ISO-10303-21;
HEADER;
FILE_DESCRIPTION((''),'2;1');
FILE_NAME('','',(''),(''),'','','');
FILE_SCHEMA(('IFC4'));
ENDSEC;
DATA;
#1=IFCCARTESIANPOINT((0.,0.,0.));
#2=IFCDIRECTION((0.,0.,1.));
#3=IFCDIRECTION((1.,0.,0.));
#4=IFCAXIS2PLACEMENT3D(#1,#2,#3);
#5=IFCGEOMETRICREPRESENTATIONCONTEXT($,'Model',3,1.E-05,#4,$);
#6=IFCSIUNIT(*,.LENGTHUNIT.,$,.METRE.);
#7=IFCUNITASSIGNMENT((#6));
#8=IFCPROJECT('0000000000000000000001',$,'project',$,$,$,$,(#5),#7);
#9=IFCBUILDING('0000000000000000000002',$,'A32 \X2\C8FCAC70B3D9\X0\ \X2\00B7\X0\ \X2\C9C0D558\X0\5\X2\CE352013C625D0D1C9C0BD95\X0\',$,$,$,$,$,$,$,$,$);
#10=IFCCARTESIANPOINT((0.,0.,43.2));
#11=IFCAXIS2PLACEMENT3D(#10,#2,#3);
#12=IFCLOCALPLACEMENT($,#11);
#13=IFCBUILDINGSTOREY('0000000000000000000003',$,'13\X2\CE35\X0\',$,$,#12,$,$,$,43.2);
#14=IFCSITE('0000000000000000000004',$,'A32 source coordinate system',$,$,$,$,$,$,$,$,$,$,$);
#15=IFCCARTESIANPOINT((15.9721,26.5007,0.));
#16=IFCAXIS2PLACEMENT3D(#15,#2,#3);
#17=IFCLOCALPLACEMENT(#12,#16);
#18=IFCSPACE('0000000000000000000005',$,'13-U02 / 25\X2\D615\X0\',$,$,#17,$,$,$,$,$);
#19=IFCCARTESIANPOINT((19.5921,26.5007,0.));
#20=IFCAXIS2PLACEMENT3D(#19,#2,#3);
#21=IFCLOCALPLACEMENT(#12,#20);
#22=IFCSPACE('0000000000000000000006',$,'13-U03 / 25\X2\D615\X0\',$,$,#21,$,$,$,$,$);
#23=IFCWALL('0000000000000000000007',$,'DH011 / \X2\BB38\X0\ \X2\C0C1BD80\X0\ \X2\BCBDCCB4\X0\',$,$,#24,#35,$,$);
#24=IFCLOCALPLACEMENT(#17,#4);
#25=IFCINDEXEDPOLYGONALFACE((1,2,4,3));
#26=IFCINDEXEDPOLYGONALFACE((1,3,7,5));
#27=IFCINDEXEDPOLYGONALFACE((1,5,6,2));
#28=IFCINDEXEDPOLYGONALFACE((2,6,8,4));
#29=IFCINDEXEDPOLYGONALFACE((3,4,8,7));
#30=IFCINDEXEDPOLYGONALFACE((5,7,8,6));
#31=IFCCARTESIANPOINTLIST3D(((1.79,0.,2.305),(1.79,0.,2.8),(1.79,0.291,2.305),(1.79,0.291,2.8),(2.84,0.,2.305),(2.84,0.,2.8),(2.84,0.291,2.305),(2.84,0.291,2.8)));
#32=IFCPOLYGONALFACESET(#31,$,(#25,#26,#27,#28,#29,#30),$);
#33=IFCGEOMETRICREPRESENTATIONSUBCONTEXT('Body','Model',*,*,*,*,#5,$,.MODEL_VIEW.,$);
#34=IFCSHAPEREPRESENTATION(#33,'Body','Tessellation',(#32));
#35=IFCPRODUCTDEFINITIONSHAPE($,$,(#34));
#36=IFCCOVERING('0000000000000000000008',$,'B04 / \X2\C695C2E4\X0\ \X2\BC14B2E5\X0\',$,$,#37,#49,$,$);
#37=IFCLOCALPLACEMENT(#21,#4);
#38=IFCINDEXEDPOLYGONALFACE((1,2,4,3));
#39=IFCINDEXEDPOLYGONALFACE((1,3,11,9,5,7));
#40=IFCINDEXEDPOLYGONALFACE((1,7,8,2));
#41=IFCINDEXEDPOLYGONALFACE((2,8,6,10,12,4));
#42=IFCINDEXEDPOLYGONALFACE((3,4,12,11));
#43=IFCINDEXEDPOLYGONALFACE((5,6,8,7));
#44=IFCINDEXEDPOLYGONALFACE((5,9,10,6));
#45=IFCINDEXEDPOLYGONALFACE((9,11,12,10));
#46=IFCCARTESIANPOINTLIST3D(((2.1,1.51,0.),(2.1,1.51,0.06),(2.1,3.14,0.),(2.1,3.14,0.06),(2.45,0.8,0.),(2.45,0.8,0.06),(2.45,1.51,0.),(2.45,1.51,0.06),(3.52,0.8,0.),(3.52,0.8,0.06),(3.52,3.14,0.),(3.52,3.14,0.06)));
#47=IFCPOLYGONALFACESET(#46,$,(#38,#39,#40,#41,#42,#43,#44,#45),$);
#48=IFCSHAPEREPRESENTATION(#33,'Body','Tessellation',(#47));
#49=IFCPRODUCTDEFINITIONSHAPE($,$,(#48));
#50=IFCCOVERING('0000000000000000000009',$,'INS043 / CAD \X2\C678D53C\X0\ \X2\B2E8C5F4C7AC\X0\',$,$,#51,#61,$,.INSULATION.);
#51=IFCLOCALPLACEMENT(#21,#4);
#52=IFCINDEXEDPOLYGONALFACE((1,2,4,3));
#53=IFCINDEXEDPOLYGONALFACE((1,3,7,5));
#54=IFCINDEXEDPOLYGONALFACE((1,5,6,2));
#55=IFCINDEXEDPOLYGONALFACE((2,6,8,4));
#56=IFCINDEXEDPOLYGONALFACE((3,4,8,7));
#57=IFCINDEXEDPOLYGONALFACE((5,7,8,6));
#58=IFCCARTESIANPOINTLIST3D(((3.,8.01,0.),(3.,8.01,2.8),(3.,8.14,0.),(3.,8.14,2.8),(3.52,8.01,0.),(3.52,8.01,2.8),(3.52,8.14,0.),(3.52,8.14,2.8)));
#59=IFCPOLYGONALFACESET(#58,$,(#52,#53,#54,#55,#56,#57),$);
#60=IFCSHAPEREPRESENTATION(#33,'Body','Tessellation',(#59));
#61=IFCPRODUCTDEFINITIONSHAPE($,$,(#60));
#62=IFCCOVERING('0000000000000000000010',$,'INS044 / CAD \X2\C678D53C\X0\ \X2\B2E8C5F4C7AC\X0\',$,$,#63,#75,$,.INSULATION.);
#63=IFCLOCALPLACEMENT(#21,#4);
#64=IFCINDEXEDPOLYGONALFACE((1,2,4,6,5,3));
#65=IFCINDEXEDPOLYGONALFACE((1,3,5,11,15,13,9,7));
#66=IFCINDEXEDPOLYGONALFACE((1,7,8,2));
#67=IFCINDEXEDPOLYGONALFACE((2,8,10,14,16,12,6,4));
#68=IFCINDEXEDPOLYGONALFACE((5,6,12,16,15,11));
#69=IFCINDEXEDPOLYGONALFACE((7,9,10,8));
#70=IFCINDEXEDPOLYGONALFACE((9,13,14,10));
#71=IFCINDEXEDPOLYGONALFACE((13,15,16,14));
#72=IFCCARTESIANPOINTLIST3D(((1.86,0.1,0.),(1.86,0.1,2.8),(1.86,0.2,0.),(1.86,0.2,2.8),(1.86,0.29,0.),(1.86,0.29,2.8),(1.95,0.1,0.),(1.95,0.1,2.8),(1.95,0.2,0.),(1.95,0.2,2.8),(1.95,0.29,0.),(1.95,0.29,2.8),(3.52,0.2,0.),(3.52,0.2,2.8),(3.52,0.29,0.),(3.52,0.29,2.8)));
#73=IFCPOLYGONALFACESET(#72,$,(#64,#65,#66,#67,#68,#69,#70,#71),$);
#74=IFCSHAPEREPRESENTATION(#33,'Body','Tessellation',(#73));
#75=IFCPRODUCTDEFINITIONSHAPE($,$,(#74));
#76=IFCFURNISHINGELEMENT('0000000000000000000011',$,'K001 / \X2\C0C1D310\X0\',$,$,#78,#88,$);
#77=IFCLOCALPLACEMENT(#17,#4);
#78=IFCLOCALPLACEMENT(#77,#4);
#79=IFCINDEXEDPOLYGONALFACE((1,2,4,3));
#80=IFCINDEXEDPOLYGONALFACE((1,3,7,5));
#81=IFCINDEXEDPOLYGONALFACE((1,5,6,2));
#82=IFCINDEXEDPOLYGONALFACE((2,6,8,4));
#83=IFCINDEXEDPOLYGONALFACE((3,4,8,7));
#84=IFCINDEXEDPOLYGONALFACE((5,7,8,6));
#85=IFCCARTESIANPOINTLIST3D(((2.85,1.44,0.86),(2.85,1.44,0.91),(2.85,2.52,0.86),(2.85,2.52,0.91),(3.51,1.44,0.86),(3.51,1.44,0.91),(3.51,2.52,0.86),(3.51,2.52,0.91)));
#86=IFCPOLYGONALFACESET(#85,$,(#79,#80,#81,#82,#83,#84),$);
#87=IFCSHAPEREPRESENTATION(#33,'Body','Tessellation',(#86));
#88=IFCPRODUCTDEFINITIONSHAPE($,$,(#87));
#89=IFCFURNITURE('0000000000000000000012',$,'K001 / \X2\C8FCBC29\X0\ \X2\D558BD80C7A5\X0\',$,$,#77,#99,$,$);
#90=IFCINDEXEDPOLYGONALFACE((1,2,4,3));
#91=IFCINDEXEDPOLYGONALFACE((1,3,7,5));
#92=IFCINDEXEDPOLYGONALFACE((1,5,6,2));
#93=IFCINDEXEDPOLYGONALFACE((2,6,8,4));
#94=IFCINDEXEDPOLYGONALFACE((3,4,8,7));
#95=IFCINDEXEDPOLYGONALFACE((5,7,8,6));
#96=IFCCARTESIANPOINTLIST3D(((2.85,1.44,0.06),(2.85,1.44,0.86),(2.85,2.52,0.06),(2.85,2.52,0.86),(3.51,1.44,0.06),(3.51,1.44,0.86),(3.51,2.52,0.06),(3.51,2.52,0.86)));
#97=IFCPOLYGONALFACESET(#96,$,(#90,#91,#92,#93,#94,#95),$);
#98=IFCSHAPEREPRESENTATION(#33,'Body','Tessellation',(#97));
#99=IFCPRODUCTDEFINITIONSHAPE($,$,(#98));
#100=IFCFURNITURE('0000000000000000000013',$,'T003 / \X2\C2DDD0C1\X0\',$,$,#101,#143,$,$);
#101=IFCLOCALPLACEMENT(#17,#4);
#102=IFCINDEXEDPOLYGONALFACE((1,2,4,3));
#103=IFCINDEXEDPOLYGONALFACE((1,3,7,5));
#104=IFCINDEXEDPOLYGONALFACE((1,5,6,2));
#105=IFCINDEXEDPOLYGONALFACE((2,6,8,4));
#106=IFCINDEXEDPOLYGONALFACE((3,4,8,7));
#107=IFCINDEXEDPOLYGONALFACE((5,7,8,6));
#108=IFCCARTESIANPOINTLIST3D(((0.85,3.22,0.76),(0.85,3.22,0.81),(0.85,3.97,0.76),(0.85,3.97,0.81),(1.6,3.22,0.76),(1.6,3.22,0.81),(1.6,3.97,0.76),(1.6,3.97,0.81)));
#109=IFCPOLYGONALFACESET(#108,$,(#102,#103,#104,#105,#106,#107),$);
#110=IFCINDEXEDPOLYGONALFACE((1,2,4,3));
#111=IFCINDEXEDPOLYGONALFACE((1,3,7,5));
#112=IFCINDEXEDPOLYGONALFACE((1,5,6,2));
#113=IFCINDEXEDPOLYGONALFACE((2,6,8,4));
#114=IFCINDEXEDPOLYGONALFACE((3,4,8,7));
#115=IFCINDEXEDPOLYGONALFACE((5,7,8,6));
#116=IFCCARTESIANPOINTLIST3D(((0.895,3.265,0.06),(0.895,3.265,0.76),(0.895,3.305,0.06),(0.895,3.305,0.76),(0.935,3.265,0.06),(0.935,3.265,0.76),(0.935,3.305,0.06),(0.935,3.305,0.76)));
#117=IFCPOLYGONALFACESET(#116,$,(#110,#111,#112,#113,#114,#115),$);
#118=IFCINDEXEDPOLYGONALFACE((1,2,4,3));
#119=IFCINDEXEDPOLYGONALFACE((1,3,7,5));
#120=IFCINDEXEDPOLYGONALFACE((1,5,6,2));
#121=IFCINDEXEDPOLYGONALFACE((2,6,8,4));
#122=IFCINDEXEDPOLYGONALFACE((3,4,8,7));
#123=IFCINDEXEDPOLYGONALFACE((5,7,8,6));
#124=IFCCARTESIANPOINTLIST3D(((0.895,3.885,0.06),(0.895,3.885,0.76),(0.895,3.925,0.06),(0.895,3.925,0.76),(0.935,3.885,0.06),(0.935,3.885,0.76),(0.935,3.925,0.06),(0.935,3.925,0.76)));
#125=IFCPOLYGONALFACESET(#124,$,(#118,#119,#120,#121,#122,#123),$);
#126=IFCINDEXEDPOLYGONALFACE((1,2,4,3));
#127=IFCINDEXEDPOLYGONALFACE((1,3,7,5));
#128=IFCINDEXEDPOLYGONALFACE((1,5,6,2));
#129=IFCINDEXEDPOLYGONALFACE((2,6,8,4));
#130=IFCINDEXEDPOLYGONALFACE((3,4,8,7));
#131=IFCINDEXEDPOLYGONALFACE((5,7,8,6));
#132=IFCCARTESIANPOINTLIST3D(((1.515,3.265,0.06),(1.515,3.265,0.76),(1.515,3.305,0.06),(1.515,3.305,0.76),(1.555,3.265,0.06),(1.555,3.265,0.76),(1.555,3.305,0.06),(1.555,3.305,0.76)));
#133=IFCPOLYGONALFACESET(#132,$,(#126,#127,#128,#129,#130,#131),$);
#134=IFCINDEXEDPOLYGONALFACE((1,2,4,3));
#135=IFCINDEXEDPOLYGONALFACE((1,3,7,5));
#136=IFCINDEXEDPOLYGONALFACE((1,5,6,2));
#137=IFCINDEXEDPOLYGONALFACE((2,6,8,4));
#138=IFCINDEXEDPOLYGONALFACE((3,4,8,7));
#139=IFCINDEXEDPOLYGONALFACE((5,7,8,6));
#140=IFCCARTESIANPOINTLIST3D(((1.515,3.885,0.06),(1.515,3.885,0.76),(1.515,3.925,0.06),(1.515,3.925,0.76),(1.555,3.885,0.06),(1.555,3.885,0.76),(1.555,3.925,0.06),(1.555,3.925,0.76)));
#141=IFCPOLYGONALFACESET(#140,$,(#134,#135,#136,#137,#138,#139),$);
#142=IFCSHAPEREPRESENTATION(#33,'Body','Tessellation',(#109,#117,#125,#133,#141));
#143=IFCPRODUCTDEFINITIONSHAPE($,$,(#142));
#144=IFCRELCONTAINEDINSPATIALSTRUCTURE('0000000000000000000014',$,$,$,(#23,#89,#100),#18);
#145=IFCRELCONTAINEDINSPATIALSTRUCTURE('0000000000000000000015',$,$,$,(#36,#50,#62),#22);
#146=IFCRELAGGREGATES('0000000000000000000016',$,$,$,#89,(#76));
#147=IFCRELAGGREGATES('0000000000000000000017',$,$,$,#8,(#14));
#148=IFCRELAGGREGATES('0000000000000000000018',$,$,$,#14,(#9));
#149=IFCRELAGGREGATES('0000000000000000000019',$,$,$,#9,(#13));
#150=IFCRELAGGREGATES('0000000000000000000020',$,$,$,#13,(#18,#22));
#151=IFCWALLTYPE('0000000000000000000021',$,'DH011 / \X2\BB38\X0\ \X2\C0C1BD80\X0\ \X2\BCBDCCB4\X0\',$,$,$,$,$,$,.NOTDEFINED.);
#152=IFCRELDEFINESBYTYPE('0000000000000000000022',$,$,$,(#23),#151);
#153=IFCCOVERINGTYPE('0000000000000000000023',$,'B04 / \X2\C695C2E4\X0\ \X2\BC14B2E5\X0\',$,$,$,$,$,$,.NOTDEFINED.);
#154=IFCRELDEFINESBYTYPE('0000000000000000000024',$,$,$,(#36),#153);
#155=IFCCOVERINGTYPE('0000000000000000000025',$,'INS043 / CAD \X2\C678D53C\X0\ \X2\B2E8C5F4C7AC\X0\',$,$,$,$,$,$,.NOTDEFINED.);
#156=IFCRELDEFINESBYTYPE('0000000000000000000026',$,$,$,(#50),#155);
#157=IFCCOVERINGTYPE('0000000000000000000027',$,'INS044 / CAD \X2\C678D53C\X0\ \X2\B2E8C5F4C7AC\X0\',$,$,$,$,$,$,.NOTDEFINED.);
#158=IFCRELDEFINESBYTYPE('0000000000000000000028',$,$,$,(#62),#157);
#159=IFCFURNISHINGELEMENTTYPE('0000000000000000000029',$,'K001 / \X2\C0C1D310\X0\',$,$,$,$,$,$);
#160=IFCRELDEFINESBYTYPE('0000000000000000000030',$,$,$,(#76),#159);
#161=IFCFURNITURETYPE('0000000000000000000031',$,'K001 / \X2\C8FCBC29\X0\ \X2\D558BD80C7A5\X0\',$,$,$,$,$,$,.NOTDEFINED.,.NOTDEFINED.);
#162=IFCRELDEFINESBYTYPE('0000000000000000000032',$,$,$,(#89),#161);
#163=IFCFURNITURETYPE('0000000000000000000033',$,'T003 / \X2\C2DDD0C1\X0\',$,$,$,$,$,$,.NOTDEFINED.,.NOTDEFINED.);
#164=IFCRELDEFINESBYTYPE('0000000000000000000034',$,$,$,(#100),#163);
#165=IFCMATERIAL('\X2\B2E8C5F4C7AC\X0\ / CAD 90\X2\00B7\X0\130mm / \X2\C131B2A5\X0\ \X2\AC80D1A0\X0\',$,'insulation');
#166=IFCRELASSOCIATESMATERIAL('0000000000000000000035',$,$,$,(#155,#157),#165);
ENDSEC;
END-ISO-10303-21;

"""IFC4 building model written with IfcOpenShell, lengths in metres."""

from ifc_helpers import new_model, si_unit, frame, origin, origin_with_axes, place, context, subcontext, project, spatial, polyline, outline, extrude, source, transform, mapped, material, type_object, type_shapes, element, aggregate, save


model = new_model("IFC4")

# Units and contexts
model_context = context("Model", 3, precision=1e-05, world=origin_with_axes())
body_context = subcontext(model_context, "Body", "Model", "MODEL_VIEW")
ifc_project = project(units=[si_unit("LENGTHUNIT", "METRE")], contexts=[model_context])

# Site, building, storey, space
site = spatial("IfcSite", under=ifc_project, Name="A32 source coordinate system")
building = spatial("IfcBuilding", under=site, Name="A32 주거동 · 지하5층–옥탑지붕")
storey_placement = place(None, frame((0.0, 0.0, 43.2), z_axis=(0.0, 0.0, 1.0), x_axis=(1.0, 0.0, 0.0)))
storey = spatial("IfcBuildingStorey", under=building, at=storey_placement, Name="13층", Elevation=43.2)
space_1_placement = place(storey_placement, frame((15.9721, 26.5007, 0.0), z_axis=(0.0, 0.0, 1.0), x_axis=(1.0, 0.0, 0.0)))
space_1 = spatial("IfcSpace", under=storey, at=space_1_placement, Name="13-U02 / 25형")

# Wall
wall_type_1 = type_object("IfcWallType", Name="DH011 / 문 상부 벽체", PredefinedType="NOTDEFINED")
shared_shape_1 = source(origin(), body_context, "Body", "SweptSolid", [
    extrude(outline(polyline([(2.84, 0.0), (1.79, 0.0), (1.79, 0.291), (2.84, 0.291), (2.84, 0.0)])), frame((0.0, 0.0, 2.305)), (0.0, 0.0, 1.0), 0.495),
])
type_shapes(wall_type_1, [shared_shape_1])
wall_1_placement = place(space_1_placement, origin_with_axes())
element("IfcWall", 1, at=wall_1_placement, inside=space_1, type_object=wall_type_1, Name="DH011 / 문 상부 벽체", context=body_context, shape_type="MappedRepresentation", body=[
    mapped(shared_shape_1, transform((0.0, 0.0, 0.0), scale=1.0)),
])

# Shared definitions
space_2_placement = place(storey_placement, frame((19.5921, 26.5007, 0.0), z_axis=(0.0, 0.0, 1.0), x_axis=(1.0, 0.0, 0.0)))
space_2 = spatial("IfcSpace", under=storey, at=space_2_placement, Name="13-U03 / 25형")

# Coverings
covering_type_1 = type_object("IfcCoveringType", Name="B04 / 욕실 바닥", PredefinedType="NOTDEFINED")
shared_shape_2 = source(origin(), body_context, "Body", "SweptSolid", [
    extrude(outline(polyline([(2.1, 1.51), (2.1, 3.14), (3.52, 3.14), (3.52, 0.8), (2.45, 0.8), (2.45, 1.51), (2.1, 1.51)])), origin(), (0.0, 0.0, 1.0), 0.06),
])
type_shapes(covering_type_1, [shared_shape_2])
covering_1_placement = place(space_2_placement, origin_with_axes())
element("IfcCovering", 2, at=covering_1_placement, inside=space_2, type_object=covering_type_1, Name="B04 / 욕실 바닥", context=body_context, shape_type="MappedRepresentation", body=[
    mapped(shared_shape_2, transform((0.0, 0.0, 0.0), scale=1.0)),
])
ifc_material = material(Name="단열재 / CAD 90·130mm / 성능 검토", Category="insulation")
covering_type_2 = type_object("IfcCoveringType", Name="INS043 / CAD 외피 단열재", PredefinedType="NOTDEFINED", material=ifc_material)
shared_shape_3 = source(origin(), body_context, "Body", "SweptSolid", [
    extrude(outline(polyline([(3.52, 8.14), (3.52, 8.01), (3.0, 8.01), (3.0, 8.14), (3.52, 8.14)])), origin(), (0.0, 0.0, 1.0), 2.8),
])
type_shapes(covering_type_2, [shared_shape_3])
covering_2_placement = place(space_2_placement, origin_with_axes())
element("IfcCovering", 3, at=covering_2_placement, inside=space_2, type_object=covering_type_2, Name="INS043 / CAD 외피 단열재", PredefinedType="INSULATION", context=body_context, shape_type="MappedRepresentation", body=[
    mapped(shared_shape_3, transform((0.0, 0.0, 0.0), scale=1.0)),
])
covering_type_3 = type_object("IfcCoveringType", Name="INS044 / CAD 외피 단열재", PredefinedType="NOTDEFINED", material=ifc_material)
shared_shape_4 = source(origin(), body_context, "Body", "SweptSolid", [
    extrude(outline(polyline([(1.86, 0.2), (1.86, 0.29), (1.95, 0.29), (3.52, 0.29), (3.52, 0.2), (1.95, 0.2), (1.95, 0.1), (1.86, 0.1), (1.86, 0.2)])), origin(), (0.0, 0.0, 1.0), 2.8),
])
type_shapes(covering_type_3, [shared_shape_4])
covering_3_placement = place(space_2_placement, origin_with_axes())
element("IfcCovering", 4, at=covering_3_placement, inside=space_2, type_object=covering_type_3, Name="INS044 / CAD 외피 단열재", PredefinedType="INSULATION", context=body_context, shape_type="MappedRepresentation", body=[
    mapped(shared_shape_4, transform((0.0, 0.0, 0.0), scale=1.0)),
])

# Furnishing element
furnishing_element_type_1 = type_object("IfcFurnishingElementType", Name="K001 / 상판")
shared_shape_5 = source(origin(), body_context, "Body", "SweptSolid", [
    extrude(outline(polyline([(2.85, 2.52), (3.51, 2.52), (3.51, 1.44), (2.85, 1.44), (2.85, 2.52)])), frame((0.0, 0.0, 0.86)), (0.0, 0.0, 1.0), 0.05),
])
type_shapes(furnishing_element_type_1, [shared_shape_5])
furniture_1_placement = place(space_1_placement, origin_with_axes())
furnishing_1_placement = place(furniture_1_placement, origin_with_axes())
furnishing_1 = element("IfcFurnishingElement", 5, at=furnishing_1_placement, type_object=furnishing_element_type_1, Name="K001 / 상판", context=body_context, shape_type="MappedRepresentation", body=[
    mapped(shared_shape_5, transform((0.0, 0.0, 0.0), scale=1.0)),
])

# Furniture
furniture_type_1 = type_object("IfcFurnitureType", Name="K001 / 주방 하부장", AssemblyPlace="NOTDEFINED", PredefinedType="NOTDEFINED")
shared_shape_6 = source(origin(), body_context, "Body", "SweptSolid", [
    extrude(outline(polyline([(2.85, 1.44), (2.85, 2.52), (3.51, 2.52), (3.51, 1.44), (2.85, 1.44)])), frame((0.0, 0.0, 0.06)), (0.0, 0.0, 1.0), 0.8),
])
type_shapes(furniture_type_1, [shared_shape_6])
furniture_1 = element("IfcFurniture", 6, at=furniture_1_placement, inside=space_1, type_object=furniture_type_1, Name="K001 / 주방 하부장", context=body_context, shape_type="MappedRepresentation", body=[
    mapped(shared_shape_6, transform((0.0, 0.0, 0.0), scale=1.0)),
])
aggregate(furniture_1, [furnishing_1])
furniture_type_2 = type_object("IfcFurnitureType", Name="T003 / 식탁", AssemblyPlace="NOTDEFINED", PredefinedType="NOTDEFINED")
shared_shape_7 = source(origin(), body_context, "Body", "SweptSolid", [
    extrude(outline(polyline([(1.6, 3.97), (1.6, 3.22), (0.85, 3.22), (0.85, 3.97), (1.6, 3.97)])), frame((0.0, 0.0, 0.76)), (0.0, 0.0, 1.0), 0.05),
    extrude(outline(polyline([(0.895, 3.265), (0.895, 3.305), (0.935, 3.305), (0.935, 3.265), (0.895, 3.265)])), frame((0.0, 0.0, 0.06)), (0.0, 0.0, 1.0), 0.7),
    extrude(outline(polyline([(0.895, 3.885), (0.895, 3.925), (0.935, 3.925), (0.935, 3.885), (0.895, 3.885)])), frame((0.0, 0.0, 0.06)), (0.0, 0.0, 1.0), 0.7),
    extrude(outline(polyline([(1.515, 3.265), (1.515, 3.305), (1.555, 3.305), (1.555, 3.265), (1.515, 3.265)])), frame((0.0, 0.0, 0.06)), (0.0, 0.0, 1.0), 0.7),
    extrude(outline(polyline([(1.515, 3.885), (1.515, 3.925), (1.555, 3.925), (1.555, 3.885), (1.515, 3.885)])), frame((0.0, 0.0, 0.06)), (0.0, 0.0, 1.0), 0.7),
])
type_shapes(furniture_type_2, [shared_shape_7])
furniture_2_placement = place(space_1_placement, origin_with_axes())
element("IfcFurniture", 7, at=furniture_2_placement, inside=space_1, type_object=furniture_type_2, Name="T003 / 식탁", context=body_context, shape_type="MappedRepresentation", body=[
    mapped(shared_shape_7, transform((0.0, 0.0, 0.0), scale=1.0)),
])

save(model, "model.ifc")
